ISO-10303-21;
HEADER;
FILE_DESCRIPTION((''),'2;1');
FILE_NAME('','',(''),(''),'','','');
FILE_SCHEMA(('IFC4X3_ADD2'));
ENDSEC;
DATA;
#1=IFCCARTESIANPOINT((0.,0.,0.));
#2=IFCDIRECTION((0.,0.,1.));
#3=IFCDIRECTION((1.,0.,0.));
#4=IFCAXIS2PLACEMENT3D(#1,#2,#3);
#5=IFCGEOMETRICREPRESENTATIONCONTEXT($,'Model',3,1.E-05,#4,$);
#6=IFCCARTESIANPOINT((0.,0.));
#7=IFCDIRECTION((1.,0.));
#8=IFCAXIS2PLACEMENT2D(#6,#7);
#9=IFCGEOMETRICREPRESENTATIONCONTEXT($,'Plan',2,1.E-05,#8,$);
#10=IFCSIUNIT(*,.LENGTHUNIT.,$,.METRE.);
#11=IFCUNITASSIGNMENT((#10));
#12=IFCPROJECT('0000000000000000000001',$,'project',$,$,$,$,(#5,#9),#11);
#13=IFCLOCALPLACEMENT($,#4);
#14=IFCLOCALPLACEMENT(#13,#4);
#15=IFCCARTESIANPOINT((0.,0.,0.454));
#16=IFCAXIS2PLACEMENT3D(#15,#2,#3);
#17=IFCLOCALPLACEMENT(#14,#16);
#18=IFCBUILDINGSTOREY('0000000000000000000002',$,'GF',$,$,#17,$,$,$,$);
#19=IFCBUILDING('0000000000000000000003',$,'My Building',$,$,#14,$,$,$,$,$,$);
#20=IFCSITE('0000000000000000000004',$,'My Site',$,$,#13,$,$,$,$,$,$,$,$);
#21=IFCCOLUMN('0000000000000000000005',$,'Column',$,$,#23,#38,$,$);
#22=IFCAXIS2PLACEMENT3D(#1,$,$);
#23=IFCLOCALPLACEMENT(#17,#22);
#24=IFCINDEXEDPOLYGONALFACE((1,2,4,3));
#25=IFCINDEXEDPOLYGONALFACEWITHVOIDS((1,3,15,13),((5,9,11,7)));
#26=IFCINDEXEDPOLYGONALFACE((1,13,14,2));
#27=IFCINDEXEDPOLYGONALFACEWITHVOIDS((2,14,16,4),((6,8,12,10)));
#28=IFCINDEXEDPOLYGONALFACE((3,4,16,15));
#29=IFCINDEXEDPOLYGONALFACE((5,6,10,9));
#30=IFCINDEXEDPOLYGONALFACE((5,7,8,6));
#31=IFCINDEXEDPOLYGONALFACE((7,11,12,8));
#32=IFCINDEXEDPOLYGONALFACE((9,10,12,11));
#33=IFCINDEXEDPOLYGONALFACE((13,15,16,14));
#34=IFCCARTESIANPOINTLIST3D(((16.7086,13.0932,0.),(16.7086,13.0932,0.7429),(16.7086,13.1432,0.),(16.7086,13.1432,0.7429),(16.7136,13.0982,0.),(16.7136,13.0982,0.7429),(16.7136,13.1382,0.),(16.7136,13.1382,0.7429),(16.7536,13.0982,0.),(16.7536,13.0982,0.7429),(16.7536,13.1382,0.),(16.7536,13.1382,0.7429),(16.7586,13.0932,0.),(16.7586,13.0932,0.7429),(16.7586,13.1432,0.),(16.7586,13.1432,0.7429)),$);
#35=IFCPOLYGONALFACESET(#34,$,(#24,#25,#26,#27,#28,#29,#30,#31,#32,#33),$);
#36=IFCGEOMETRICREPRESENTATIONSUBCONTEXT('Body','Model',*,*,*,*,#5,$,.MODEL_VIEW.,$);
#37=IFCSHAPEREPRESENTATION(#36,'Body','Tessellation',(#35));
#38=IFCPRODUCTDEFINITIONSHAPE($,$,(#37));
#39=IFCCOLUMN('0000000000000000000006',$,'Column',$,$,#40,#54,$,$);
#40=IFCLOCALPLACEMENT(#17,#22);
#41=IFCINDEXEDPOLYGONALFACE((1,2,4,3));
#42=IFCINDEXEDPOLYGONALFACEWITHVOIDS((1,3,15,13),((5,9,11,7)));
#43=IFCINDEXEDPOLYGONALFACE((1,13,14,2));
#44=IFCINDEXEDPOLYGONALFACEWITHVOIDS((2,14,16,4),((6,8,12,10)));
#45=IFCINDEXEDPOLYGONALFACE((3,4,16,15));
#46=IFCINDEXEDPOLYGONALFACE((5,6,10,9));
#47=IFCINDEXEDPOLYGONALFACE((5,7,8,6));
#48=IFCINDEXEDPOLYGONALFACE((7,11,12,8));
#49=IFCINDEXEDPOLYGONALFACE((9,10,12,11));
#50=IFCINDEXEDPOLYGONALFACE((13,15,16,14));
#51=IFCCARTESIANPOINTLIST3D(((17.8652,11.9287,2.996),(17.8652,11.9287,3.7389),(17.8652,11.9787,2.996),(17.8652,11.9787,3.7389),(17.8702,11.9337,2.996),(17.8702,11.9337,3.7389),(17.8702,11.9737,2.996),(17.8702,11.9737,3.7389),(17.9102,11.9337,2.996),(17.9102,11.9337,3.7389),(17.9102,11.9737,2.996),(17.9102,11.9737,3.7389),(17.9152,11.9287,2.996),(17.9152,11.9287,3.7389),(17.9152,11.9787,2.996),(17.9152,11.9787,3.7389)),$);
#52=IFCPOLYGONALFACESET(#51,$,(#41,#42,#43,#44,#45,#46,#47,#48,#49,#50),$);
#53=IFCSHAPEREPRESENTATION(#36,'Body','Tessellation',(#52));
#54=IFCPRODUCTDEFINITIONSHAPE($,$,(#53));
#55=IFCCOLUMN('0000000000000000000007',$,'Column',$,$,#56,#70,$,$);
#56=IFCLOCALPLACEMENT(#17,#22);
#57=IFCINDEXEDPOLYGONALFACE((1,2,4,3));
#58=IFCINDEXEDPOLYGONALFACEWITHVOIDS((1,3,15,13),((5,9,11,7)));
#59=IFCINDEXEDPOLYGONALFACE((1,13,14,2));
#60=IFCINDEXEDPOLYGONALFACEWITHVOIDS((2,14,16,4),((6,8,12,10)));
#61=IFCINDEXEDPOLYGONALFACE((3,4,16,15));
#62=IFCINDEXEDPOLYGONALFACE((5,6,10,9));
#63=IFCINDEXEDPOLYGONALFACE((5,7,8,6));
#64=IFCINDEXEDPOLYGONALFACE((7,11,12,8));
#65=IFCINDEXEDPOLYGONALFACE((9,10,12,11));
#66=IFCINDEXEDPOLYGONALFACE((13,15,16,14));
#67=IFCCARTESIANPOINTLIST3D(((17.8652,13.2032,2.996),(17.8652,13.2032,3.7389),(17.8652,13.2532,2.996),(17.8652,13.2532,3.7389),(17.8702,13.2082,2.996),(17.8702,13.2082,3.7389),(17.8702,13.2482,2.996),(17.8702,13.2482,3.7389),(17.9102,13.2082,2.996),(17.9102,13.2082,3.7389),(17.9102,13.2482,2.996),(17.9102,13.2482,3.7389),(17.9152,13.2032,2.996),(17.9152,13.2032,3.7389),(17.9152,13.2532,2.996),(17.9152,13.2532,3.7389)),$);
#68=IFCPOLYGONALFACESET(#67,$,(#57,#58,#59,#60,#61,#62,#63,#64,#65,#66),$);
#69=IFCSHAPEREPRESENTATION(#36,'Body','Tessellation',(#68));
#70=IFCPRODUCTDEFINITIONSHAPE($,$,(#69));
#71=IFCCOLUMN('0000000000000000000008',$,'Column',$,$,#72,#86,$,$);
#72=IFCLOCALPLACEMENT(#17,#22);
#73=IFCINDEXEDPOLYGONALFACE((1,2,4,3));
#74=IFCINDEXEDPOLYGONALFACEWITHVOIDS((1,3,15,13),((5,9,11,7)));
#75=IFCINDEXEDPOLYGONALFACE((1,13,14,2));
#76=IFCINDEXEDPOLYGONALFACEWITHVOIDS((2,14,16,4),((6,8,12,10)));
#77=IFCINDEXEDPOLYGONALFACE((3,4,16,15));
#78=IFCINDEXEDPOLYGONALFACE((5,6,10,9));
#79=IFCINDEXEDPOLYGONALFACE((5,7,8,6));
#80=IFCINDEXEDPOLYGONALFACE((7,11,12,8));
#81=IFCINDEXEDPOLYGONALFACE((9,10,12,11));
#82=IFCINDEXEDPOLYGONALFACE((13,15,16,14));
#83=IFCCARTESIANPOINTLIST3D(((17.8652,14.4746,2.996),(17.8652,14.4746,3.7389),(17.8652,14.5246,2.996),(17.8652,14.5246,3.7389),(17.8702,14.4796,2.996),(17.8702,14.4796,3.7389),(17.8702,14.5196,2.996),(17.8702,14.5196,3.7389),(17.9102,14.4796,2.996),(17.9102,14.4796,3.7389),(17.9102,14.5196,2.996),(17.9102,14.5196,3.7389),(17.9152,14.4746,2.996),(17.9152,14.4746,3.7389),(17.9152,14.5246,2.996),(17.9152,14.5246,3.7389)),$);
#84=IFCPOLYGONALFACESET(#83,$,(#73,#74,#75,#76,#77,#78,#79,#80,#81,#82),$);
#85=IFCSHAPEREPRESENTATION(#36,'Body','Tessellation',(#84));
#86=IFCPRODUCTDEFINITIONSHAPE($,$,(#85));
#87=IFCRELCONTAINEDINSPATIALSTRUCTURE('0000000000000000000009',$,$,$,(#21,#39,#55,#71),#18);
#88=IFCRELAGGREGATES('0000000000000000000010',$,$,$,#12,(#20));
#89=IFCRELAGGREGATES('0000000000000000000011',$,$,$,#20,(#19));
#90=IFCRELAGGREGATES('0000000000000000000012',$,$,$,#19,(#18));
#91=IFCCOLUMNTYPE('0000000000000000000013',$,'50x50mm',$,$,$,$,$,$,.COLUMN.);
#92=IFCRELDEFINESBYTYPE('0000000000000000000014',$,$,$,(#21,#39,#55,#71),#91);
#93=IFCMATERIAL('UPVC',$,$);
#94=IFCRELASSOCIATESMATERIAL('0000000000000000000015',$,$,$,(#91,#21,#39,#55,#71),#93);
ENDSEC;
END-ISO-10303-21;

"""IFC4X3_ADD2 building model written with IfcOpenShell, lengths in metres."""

from ifc_helpers import new_model, si_unit, frame, origin_with_axes, origin_2d_with_axis, place, context, subcontext, project, spatial, hollow_rectangle, extrude, material, material_profile, profile_set, profile_usage, type_object, element, save


model = new_model("IFC4X3_ADD2")

# Units and contexts
model_context = context("Model", 3, precision=1e-05, world=origin_with_axes())
plan_context = context("Plan", 2, precision=1e-05, world=origin_2d_with_axis())
body_context = subcontext(model_context, "Body", "Model", "MODEL_VIEW")
ifc_project = project(units=[si_unit("LENGTHUNIT", "METRE")], contexts=[model_context, plan_context])

# Site, building, storey
site_placement = place(None, origin_with_axes())
site = spatial("IfcSite", under=ifc_project, at=site_placement, Name="My Site")
building_placement = place(site_placement, origin_with_axes())
building = spatial("IfcBuilding", under=site, at=building_placement, Name="My Building")
storey_placement = place(building_placement, frame((0.0, 0.0, 0.454), z_axis=(0.0, 0.0, 1.0), x_axis=(1.0, 0.0, 0.0)))
storey = spatial("IfcBuildingStorey", under=building, at=storey_placement, Name="GF")

# Columns
ifc_material = material(Name="UPVC")
ifc_material_profile_1 = material_profile(ifc_material, hollow_rectangle(XDim=0.05, YDim=0.05, WallThickness=0.005))
ifc_profile_set_1 = profile_set([ifc_material_profile_1])
column_type_1 = type_object("IfcColumnType", Name="50x50mm", PredefinedType="COLUMN", material=ifc_profile_set_1)
ifc_profile_usage_1 = profile_usage(ifc_profile_set_1)
column_1_placement = place(storey_placement, frame((16.7336, 13.1182, 0.0), z_axis=(0.0, 0.0, 1.0), x_axis=(0.0, -1.0, 0.0)))
element("IfcColumn", 1, at=column_1_placement, inside=storey, type_object=column_type_1, material=ifc_profile_usage_1, Name="Column", context=body_context, shape_type="SweptSolid", body=[
    extrude(hollow_rectangle(XDim=0.05, YDim=0.05, WallThickness=0.005), origin_with_axes(), (0.0, 0.0, 1.0), 0.7429),
])
ifc_profile_usage_2 = profile_usage(ifc_profile_set_1)
column_2_placement = place(storey_placement, frame((17.8902, 11.9537, 2.996), z_axis=(0.0, 0.0, 1.0), x_axis=(0.0, -1.0, 0.0)))
element("IfcColumn", 2, at=column_2_placement, inside=storey, type_object=column_type_1, material=ifc_profile_usage_2, Name="Column", context=body_context, shape_type="SweptSolid", body=[
    extrude(hollow_rectangle(XDim=0.05, YDim=0.05, WallThickness=0.005), origin_with_axes(), (0.0, 0.0, 1.0), 0.7429),
])
ifc_profile_usage_3 = profile_usage(ifc_profile_set_1)
column_3_placement = place(storey_placement, frame((17.8902, 13.2282, 2.996), z_axis=(0.0, 0.0, 1.0), x_axis=(0.0, -1.0, 0.0)))
element("IfcColumn", 3, at=column_3_placement, inside=storey, type_object=column_type_1, material=ifc_profile_usage_3, Name="Column", context=body_context, shape_type="SweptSolid", body=[
    extrude(hollow_rectangle(XDim=0.05, YDim=0.05, WallThickness=0.005), origin_with_axes(), (0.0, 0.0, 1.0), 0.7429),
])
ifc_profile_usage_4 = profile_usage(ifc_profile_set_1)
column_4_placement = place(storey_placement, frame((17.8902, 14.4996, 2.996), z_axis=(0.0, 0.0, 1.0), x_axis=(0.0, -1.0, 0.0)))
element("IfcColumn", 4, at=column_4_placement, inside=storey, type_object=column_type_1, material=ifc_profile_usage_4, Name="Column", context=body_context, shape_type="SweptSolid", body=[
    extrude(hollow_rectangle(XDim=0.05, YDim=0.05, WallThickness=0.005), origin_with_axes(), (0.0, 0.0, 1.0), 0.7429),
])

save(model, "model.ifc")
